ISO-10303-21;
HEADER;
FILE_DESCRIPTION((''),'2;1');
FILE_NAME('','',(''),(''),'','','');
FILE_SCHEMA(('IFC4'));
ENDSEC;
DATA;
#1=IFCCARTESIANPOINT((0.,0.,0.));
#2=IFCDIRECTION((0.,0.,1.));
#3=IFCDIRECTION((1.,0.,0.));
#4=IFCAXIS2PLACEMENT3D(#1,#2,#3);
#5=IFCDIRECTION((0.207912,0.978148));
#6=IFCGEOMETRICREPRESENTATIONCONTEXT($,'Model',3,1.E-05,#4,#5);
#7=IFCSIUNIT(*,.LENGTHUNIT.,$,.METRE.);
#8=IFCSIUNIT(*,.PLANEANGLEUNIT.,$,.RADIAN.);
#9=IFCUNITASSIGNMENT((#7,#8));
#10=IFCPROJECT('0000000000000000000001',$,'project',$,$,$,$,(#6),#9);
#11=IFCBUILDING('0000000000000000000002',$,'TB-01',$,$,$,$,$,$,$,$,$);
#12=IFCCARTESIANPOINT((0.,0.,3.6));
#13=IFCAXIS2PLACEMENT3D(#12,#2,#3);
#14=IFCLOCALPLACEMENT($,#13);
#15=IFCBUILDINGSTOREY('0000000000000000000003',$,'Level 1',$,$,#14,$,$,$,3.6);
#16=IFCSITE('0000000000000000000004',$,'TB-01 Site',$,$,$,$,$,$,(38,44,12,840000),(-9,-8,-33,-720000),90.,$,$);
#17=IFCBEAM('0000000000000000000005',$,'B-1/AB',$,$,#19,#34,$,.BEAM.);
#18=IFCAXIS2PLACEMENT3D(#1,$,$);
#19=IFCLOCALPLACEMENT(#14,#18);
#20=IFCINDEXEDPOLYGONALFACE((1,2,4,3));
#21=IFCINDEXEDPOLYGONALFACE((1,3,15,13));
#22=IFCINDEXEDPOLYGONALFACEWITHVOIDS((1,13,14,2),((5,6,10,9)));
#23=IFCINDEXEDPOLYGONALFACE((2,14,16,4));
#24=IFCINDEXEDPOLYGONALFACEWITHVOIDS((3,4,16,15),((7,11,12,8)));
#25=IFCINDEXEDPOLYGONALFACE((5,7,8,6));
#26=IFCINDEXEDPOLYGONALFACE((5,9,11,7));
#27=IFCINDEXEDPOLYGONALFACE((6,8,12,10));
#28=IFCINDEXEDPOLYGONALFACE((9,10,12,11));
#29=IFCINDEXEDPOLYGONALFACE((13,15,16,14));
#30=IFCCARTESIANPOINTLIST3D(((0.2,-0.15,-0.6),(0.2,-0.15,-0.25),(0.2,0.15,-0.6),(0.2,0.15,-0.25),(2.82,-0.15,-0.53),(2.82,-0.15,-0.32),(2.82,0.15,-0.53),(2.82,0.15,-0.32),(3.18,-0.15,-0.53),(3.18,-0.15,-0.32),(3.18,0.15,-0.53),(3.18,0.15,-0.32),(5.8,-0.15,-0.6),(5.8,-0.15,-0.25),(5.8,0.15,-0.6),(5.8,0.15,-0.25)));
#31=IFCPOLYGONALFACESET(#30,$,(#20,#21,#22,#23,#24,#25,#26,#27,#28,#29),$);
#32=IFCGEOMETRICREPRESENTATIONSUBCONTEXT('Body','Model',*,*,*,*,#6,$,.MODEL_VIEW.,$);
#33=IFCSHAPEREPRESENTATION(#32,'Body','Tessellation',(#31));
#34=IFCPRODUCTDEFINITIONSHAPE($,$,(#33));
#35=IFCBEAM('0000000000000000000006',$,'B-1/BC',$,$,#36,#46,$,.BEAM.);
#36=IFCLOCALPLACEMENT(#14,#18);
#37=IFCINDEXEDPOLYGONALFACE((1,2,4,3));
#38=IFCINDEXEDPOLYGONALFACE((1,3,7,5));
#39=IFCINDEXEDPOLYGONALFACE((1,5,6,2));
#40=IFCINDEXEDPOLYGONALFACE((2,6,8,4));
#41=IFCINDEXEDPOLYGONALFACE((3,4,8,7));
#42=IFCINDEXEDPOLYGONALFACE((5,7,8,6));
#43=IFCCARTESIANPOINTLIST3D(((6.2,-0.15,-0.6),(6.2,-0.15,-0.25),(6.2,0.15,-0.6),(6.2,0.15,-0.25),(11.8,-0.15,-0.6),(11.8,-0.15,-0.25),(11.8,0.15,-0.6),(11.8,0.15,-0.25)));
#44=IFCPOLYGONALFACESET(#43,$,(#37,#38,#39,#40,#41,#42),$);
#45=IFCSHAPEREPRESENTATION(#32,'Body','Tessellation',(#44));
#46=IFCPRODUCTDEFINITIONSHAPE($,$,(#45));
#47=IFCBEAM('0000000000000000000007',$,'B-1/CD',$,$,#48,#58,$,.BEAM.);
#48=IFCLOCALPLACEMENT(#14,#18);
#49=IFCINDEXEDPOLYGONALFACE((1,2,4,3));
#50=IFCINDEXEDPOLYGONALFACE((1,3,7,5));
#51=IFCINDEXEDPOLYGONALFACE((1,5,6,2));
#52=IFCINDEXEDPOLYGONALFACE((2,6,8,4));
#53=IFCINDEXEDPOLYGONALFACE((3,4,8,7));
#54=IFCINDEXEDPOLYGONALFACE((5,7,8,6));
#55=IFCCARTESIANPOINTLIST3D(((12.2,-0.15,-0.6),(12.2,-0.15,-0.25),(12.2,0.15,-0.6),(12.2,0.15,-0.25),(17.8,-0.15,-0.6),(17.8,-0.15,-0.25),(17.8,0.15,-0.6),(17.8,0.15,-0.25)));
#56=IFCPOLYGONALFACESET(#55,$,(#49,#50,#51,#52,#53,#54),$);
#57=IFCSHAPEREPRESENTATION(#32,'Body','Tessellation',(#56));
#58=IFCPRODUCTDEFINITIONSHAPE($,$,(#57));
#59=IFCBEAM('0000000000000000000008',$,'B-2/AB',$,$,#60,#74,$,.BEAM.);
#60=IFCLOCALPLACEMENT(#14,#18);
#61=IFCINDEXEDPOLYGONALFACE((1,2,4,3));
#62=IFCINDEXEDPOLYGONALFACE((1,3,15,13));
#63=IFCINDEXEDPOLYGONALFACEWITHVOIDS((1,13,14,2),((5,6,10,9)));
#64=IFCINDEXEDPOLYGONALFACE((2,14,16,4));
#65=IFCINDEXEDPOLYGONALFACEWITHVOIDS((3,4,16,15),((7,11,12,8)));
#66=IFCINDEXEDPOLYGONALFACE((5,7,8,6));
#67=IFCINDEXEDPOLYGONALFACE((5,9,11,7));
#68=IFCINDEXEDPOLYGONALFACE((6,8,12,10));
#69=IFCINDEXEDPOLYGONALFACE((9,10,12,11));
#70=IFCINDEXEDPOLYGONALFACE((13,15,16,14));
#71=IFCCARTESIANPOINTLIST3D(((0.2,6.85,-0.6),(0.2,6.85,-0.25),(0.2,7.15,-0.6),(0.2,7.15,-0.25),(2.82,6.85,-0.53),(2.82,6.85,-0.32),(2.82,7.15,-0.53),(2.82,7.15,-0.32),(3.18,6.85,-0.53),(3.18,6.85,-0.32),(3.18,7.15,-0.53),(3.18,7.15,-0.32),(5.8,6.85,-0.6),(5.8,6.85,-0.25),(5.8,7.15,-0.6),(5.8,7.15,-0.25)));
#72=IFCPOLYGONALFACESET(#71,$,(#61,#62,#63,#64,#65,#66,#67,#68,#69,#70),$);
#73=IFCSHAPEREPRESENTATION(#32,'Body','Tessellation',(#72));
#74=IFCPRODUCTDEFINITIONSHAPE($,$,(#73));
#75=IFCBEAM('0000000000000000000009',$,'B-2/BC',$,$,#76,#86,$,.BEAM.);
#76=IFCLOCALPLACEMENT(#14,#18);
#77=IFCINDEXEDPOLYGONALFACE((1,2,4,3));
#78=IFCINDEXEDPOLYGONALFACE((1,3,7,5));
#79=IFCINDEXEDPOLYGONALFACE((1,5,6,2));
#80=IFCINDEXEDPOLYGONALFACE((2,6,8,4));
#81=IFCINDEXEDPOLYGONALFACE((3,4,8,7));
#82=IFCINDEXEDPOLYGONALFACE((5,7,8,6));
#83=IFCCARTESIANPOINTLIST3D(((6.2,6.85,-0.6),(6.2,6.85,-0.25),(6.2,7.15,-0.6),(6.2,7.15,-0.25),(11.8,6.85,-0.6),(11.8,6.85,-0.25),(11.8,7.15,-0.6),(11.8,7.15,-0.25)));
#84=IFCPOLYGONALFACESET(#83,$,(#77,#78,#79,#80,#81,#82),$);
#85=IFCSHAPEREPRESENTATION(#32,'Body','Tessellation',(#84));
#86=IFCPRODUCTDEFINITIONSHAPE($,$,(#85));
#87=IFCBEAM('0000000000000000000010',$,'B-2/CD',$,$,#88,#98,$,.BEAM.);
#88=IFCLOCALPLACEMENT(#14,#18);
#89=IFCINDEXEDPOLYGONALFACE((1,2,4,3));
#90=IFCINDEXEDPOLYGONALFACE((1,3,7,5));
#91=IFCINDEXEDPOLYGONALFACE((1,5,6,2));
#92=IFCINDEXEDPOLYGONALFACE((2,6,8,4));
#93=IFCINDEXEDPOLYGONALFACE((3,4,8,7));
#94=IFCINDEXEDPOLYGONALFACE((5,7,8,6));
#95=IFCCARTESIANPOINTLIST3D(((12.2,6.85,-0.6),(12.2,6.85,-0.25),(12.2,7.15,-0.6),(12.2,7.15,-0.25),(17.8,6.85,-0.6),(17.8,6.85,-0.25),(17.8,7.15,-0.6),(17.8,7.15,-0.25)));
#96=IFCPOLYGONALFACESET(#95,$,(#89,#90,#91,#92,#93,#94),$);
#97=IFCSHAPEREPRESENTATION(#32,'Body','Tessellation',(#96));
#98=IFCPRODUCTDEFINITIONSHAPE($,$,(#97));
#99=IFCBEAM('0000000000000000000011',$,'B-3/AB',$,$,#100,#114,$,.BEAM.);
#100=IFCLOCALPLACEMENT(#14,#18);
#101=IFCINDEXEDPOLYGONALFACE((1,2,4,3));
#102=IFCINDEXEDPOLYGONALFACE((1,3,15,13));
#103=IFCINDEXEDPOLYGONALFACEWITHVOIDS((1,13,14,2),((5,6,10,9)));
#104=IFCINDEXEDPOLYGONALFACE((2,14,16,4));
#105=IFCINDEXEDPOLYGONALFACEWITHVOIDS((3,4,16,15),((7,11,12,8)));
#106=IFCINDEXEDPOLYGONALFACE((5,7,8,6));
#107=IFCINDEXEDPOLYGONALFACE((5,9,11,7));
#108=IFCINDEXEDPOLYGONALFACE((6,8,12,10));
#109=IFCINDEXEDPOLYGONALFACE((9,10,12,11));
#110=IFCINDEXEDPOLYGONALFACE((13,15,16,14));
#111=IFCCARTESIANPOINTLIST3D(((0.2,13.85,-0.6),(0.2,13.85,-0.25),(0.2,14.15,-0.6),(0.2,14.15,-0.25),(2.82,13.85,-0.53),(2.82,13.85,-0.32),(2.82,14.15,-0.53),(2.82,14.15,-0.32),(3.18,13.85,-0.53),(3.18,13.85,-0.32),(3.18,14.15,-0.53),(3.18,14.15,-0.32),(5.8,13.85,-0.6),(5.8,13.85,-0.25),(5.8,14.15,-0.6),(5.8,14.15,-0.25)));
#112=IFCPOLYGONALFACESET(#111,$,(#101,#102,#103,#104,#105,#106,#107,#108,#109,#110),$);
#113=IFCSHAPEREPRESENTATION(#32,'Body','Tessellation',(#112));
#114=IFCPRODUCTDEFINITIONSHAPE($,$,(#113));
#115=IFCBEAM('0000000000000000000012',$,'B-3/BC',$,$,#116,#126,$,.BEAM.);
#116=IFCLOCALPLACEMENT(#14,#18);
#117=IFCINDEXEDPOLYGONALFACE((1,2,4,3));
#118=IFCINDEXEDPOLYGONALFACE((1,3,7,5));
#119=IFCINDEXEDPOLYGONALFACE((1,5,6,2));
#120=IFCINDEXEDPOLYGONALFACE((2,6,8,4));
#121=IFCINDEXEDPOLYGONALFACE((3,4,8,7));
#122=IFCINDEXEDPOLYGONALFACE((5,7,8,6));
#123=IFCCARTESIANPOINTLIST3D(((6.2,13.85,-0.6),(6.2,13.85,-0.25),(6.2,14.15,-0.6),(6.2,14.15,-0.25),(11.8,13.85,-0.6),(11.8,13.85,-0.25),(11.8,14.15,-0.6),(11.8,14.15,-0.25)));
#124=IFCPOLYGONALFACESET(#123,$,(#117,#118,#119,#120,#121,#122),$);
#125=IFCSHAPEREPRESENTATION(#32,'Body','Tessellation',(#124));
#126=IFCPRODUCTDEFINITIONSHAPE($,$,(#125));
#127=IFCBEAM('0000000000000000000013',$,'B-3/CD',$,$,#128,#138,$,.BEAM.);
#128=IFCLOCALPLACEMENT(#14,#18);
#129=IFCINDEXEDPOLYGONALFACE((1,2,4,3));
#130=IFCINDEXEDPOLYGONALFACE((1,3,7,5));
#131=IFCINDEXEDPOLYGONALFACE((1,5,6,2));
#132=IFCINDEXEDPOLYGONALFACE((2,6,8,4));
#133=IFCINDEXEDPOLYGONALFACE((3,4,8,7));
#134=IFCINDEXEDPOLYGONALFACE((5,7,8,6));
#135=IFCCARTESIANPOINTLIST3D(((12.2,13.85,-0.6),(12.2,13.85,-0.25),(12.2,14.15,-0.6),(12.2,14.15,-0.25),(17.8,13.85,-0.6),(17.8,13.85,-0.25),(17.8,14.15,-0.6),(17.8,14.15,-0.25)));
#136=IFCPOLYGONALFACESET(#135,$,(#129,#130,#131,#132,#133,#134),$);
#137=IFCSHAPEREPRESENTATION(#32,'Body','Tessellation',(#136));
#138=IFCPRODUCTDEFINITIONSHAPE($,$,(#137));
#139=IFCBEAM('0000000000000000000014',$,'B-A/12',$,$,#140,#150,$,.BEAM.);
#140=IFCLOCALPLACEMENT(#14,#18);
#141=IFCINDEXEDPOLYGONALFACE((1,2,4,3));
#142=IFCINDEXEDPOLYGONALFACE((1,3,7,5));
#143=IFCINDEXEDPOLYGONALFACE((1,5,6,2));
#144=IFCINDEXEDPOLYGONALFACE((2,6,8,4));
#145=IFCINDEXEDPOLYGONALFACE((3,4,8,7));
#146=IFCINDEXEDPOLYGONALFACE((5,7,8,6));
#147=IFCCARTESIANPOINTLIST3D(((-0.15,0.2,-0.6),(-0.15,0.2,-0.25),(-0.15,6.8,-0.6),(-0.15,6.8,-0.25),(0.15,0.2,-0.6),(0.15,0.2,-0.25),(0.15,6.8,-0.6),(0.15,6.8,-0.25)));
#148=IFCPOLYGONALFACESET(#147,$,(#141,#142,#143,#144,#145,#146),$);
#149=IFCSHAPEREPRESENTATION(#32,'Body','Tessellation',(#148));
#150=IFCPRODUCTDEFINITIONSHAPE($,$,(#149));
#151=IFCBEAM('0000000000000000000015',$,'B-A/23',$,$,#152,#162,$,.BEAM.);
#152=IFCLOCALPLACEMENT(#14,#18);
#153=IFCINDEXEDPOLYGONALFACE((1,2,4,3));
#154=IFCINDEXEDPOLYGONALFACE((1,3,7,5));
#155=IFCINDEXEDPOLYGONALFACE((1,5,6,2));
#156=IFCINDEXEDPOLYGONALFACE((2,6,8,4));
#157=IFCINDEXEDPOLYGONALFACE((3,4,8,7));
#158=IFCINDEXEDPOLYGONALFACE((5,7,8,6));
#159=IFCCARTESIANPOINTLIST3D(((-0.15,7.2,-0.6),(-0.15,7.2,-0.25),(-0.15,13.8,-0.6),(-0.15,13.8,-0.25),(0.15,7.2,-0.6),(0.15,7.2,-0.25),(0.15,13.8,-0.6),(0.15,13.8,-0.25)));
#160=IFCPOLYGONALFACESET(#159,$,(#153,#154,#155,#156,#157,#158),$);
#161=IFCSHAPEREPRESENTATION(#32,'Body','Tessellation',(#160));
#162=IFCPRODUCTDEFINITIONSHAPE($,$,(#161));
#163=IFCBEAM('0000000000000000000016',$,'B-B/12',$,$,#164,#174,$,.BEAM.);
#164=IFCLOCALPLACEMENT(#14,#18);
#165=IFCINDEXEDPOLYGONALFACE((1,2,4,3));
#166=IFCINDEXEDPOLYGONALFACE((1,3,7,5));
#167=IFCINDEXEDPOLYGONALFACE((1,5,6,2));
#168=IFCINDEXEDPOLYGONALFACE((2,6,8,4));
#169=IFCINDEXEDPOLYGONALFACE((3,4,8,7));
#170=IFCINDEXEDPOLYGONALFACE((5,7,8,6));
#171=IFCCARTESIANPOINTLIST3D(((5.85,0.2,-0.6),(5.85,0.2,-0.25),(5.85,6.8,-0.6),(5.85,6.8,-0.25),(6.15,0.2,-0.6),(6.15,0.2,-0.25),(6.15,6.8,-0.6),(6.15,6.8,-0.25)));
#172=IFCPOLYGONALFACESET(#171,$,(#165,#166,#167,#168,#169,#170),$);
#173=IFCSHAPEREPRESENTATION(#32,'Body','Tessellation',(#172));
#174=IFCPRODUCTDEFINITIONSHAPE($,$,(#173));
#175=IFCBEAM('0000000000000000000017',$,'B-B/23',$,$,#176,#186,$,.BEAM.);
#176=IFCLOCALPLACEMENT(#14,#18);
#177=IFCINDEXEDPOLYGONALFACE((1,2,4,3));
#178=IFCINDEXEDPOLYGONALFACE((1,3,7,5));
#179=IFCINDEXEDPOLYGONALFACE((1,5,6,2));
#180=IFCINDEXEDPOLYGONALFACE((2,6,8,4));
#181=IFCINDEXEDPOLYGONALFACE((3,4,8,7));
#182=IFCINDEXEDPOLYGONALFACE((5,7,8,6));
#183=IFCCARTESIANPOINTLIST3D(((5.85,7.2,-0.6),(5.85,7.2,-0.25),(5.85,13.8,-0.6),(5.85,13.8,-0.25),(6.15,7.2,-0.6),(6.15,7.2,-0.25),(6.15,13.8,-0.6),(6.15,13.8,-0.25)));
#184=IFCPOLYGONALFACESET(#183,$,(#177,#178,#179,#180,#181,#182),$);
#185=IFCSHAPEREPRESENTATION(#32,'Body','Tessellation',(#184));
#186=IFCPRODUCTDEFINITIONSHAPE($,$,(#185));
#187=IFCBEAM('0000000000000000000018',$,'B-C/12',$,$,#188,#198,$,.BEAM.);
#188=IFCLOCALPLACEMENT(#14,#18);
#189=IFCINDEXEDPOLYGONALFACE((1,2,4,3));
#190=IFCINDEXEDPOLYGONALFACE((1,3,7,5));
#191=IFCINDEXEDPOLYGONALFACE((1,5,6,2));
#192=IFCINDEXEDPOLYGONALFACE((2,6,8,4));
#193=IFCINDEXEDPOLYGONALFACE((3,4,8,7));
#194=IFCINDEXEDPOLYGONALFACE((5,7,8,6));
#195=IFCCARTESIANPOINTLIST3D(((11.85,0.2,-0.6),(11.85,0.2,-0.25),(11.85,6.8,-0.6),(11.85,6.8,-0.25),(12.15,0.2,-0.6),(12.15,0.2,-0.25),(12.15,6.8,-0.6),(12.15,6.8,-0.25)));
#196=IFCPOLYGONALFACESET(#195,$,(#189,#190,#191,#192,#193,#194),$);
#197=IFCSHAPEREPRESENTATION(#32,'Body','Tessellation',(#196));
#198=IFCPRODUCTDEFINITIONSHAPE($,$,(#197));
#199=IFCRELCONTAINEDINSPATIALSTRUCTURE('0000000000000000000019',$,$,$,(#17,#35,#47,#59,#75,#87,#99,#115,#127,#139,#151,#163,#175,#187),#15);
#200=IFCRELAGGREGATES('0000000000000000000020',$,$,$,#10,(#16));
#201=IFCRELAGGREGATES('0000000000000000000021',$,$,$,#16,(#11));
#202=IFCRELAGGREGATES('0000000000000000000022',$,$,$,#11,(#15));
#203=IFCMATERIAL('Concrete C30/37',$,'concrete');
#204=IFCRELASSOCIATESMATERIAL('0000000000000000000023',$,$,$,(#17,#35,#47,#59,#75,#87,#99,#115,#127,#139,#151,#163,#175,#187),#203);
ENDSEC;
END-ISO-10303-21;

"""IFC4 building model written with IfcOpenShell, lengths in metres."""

from ifc_helpers import new_model, si_unit, direction, frame, origin_with_axes, place, context, subcontext, project, spatial, rectangle, extrude, material, element, save


model = new_model("IFC4")

# Units and contexts
model_context = context("Model", 3, precision=1e-05, world=origin_with_axes(), true_north=direction((0.207912, 0.978148)))
body_context = subcontext(model_context, "Body", "Model", "MODEL_VIEW")
ifc_project = project(units=[si_unit("LENGTHUNIT", "METRE"), si_unit("PLANEANGLEUNIT", "RADIAN")], contexts=[model_context])

# Site, building, storey
site = spatial("IfcSite", under=ifc_project, Name="TB-01 Site", RefLatitude=(38, 44, 12, 840000), RefLongitude=(-9, -8, -33, -720000), RefElevation=90.0)
building = spatial("IfcBuilding", under=site, Name="TB-01")
storey_placement = place(None, frame((0.0, 0.0, 3.6), z_axis=(0.0, 0.0, 1.0), x_axis=(1.0, 0.0, 0.0)))
storey = spatial("IfcBuildingStorey", under=building, at=storey_placement, Name="Level 1", Elevation=3.6)

# Beam, opening
ifc_material = material(Name="Concrete C30/37", Category="concrete")
beam_1_placement = place(storey_placement, frame((0.2, 0.0, -0.425), z_axis=(1.0, 0.0, 0.0), x_axis=(0.0, 1.0, 0.0)))
beam_1 = element("IfcBeam", 1, at=beam_1_placement, inside=storey, material=ifc_material, Name="B-1/AB", PredefinedType="BEAM", context=body_context, shape_type="SweptSolid", body=[
    extrude(rectangle(XDim=0.3, YDim=0.35), origin_with_axes(), (0.0, 0.0, 1.0), 5.6),
])
opening_1_placement = place(beam_1_placement, frame((0.0, -0.105, 2.8), z_axis=(0.0, 1.0, 0.0), x_axis=(0.0, 0.0, 1.0)))
element("IfcOpeningElement", 2, at=opening_1_placement, cuts=beam_1, context=body_context, shape_type="SweptSolid", body=[
    extrude(rectangle(XDim=0.36, YDim=0.4), origin_with_axes(), (0.0, 0.0, 1.0), 0.21),
])

# Beams
beam_2_placement = place(storey_placement, frame((6.2, 0.0, -0.425), z_axis=(1.0, 0.0, 0.0), x_axis=(0.0, 1.0, 0.0)))
element("IfcBeam", 3, at=beam_2_placement, inside=storey, material=ifc_material, Name="B-1/BC", PredefinedType="BEAM", context=body_context, shape_type="SweptSolid", body=[
    extrude(rectangle(XDim=0.3, YDim=0.35), origin_with_axes(), (0.0, 0.0, 1.0), 5.6),
])
beam_3_placement = place(storey_placement, frame((12.2, 0.0, -0.425), z_axis=(1.0, 0.0, 0.0), x_axis=(0.0, 1.0, 0.0)))
element("IfcBeam", 4, at=beam_3_placement, inside=storey, material=ifc_material, Name="B-1/CD", PredefinedType="BEAM", context=body_context, shape_type="SweptSolid", body=[
    extrude(rectangle(XDim=0.3, YDim=0.35), origin_with_axes(), (0.0, 0.0, 1.0), 5.6),
])

# Beam, opening
beam_4_placement = place(storey_placement, frame((0.2, 7.0, -0.425), z_axis=(1.0, 0.0, 0.0), x_axis=(0.0, 1.0, 0.0)))
beam_4 = element("IfcBeam", 5, at=beam_4_placement, inside=storey, material=ifc_material, Name="B-2/AB", PredefinedType="BEAM", context=body_context, shape_type="SweptSolid", body=[
    extrude(rectangle(XDim=0.3, YDim=0.35), origin_with_axes(), (0.0, 0.0, 1.0), 5.6),
])
opening_2_placement = place(beam_4_placement, frame((0.0, -0.105, 2.8), z_axis=(0.0, 1.0, 0.0), x_axis=(0.0, 0.0, 1.0)))
element("IfcOpeningElement", 6, at=opening_2_placement, cuts=beam_4, context=body_context, shape_type="SweptSolid", body=[
    extrude(rectangle(XDim=0.36, YDim=0.4), origin_with_axes(), (0.0, 0.0, 1.0), 0.21),
])

# Beams
beam_5_placement = place(storey_placement, frame((6.2, 7.0, -0.425), z_axis=(1.0, 0.0, 0.0), x_axis=(0.0, 1.0, 0.0)))
element("IfcBeam", 7, at=beam_5_placement, inside=storey, material=ifc_material, Name="B-2/BC", PredefinedType="BEAM", context=body_context, shape_type="SweptSolid", body=[
    extrude(rectangle(XDim=0.3, YDim=0.35), origin_with_axes(), (0.0, 0.0, 1.0), 5.6),
])
beam_6_placement = place(storey_placement, frame((12.2, 7.0, -0.425), z_axis=(1.0, 0.0, 0.0), x_axis=(0.0, 1.0, 0.0)))
element("IfcBeam", 8, at=beam_6_placement, inside=storey, material=ifc_material, Name="B-2/CD", PredefinedType="BEAM", context=body_context, shape_type="SweptSolid", body=[
    extrude(rectangle(XDim=0.3, YDim=0.35), origin_with_axes(), (0.0, 0.0, 1.0), 5.6),
])

# Beam, opening
beam_7_placement = place(storey_placement, frame((0.2, 14.0, -0.425), z_axis=(1.0, 0.0, 0.0), x_axis=(0.0, 1.0, 0.0)))
beam_7 = element("IfcBeam", 9, at=beam_7_placement, inside=storey, material=ifc_material, Name="B-3/AB", PredefinedType="BEAM", context=body_context, shape_type="SweptSolid", body=[
    extrude(rectangle(XDim=0.3, YDim=0.35), origin_with_axes(), (0.0, 0.0, 1.0), 5.6),
])
opening_3_placement = place(beam_7_placement, frame((0.0, -0.105, 2.8), z_axis=(0.0, 1.0, 0.0), x_axis=(0.0, 0.0, 1.0)))
element("IfcOpeningElement", 10, at=opening_3_placement, cuts=beam_7, context=body_context, shape_type="SweptSolid", body=[
    extrude(rectangle(XDim=0.36, YDim=0.4), origin_with_axes(), (0.0, 0.0, 1.0), 0.21),
])

# Beams
beam_8_placement = place(storey_placement, frame((6.2, 14.0, -0.425), z_axis=(1.0, 0.0, 0.0), x_axis=(0.0, 1.0, 0.0)))
element("IfcBeam", 11, at=beam_8_placement, inside=storey, material=ifc_material, Name="B-3/BC", PredefinedType="BEAM", context=body_context, shape_type="SweptSolid", body=[
    extrude(rectangle(XDim=0.3, YDim=0.35), origin_with_axes(), (0.0, 0.0, 1.0), 5.6),
])
beam_9_placement = place(storey_placement, frame((12.2, 14.0, -0.425), z_axis=(1.0, 0.0, 0.0), x_axis=(0.0, 1.0, 0.0)))
element("IfcBeam", 12, at=beam_9_placement, inside=storey, material=ifc_material, Name="B-3/CD", PredefinedType="BEAM", context=body_context, shape_type="SweptSolid", body=[
    extrude(rectangle(XDim=0.3, YDim=0.35), origin_with_axes(), (0.0, 0.0, 1.0), 5.6),
])
beam_10_placement = place(storey_placement, frame((0.0, 0.2, -0.425), z_axis=(0.0, 1.0, 0.0), x_axis=(-1.0, 0.0, 0.0)))
element("IfcBeam", 13, at=beam_10_placement, inside=storey, material=ifc_material, Name="B-A/12", PredefinedType="BEAM", context=body_context, shape_type="SweptSolid", body=[
    extrude(rectangle(XDim=0.3, YDim=0.35), origin_with_axes(), (0.0, 0.0, 1.0), 6.6),
])
beam_11_placement = place(storey_placement, frame((0.0, 7.2, -0.425), z_axis=(0.0, 1.0, 0.0), x_axis=(-1.0, 0.0, 0.0)))
element("IfcBeam", 14, at=beam_11_placement, inside=storey, material=ifc_material, Name="B-A/23", PredefinedType="BEAM", context=body_context, shape_type="SweptSolid", body=[
    extrude(rectangle(XDim=0.3, YDim=0.35), origin_with_axes(), (0.0, 0.0, 1.0), 6.6),
])
beam_12_placement = place(storey_placement, frame((6.0, 0.2, -0.425), z_axis=(0.0, 1.0, 0.0), x_axis=(-1.0, 0.0, 0.0)))
element("IfcBeam", 15, at=beam_12_placement, inside=storey, material=ifc_material, Name="B-B/12", PredefinedType="BEAM", context=body_context, shape_type="SweptSolid", body=[
    extrude(rectangle(XDim=0.3, YDim=0.35), origin_with_axes(), (0.0, 0.0, 1.0), 6.6),
])
beam_13_placement = place(storey_placement, frame((6.0, 7.2, -0.425), z_axis=(0.0, 1.0, 0.0), x_axis=(-1.0, 0.0, 0.0)))
element("IfcBeam", 16, at=beam_13_placement, inside=storey, material=ifc_material, Name="B-B/23", PredefinedType="BEAM", context=body_context, shape_type="SweptSolid", body=[
    extrude(rectangle(XDim=0.3, YDim=0.35), origin_with_axes(), (0.0, 0.0, 1.0), 6.6),
])
beam_14_placement = place(storey_placement, frame((12.0, 0.2, -0.425), z_axis=(0.0, 1.0, 0.0), x_axis=(-1.0, 0.0, 0.0)))
element("IfcBeam", 17, at=beam_14_placement, inside=storey, material=ifc_material, Name="B-C/12", PredefinedType="BEAM", context=body_context, shape_type="SweptSolid", body=[
    extrude(rectangle(XDim=0.3, YDim=0.35), origin_with_axes(), (0.0, 0.0, 1.0), 6.6),
])

save(model, "model.ifc")
